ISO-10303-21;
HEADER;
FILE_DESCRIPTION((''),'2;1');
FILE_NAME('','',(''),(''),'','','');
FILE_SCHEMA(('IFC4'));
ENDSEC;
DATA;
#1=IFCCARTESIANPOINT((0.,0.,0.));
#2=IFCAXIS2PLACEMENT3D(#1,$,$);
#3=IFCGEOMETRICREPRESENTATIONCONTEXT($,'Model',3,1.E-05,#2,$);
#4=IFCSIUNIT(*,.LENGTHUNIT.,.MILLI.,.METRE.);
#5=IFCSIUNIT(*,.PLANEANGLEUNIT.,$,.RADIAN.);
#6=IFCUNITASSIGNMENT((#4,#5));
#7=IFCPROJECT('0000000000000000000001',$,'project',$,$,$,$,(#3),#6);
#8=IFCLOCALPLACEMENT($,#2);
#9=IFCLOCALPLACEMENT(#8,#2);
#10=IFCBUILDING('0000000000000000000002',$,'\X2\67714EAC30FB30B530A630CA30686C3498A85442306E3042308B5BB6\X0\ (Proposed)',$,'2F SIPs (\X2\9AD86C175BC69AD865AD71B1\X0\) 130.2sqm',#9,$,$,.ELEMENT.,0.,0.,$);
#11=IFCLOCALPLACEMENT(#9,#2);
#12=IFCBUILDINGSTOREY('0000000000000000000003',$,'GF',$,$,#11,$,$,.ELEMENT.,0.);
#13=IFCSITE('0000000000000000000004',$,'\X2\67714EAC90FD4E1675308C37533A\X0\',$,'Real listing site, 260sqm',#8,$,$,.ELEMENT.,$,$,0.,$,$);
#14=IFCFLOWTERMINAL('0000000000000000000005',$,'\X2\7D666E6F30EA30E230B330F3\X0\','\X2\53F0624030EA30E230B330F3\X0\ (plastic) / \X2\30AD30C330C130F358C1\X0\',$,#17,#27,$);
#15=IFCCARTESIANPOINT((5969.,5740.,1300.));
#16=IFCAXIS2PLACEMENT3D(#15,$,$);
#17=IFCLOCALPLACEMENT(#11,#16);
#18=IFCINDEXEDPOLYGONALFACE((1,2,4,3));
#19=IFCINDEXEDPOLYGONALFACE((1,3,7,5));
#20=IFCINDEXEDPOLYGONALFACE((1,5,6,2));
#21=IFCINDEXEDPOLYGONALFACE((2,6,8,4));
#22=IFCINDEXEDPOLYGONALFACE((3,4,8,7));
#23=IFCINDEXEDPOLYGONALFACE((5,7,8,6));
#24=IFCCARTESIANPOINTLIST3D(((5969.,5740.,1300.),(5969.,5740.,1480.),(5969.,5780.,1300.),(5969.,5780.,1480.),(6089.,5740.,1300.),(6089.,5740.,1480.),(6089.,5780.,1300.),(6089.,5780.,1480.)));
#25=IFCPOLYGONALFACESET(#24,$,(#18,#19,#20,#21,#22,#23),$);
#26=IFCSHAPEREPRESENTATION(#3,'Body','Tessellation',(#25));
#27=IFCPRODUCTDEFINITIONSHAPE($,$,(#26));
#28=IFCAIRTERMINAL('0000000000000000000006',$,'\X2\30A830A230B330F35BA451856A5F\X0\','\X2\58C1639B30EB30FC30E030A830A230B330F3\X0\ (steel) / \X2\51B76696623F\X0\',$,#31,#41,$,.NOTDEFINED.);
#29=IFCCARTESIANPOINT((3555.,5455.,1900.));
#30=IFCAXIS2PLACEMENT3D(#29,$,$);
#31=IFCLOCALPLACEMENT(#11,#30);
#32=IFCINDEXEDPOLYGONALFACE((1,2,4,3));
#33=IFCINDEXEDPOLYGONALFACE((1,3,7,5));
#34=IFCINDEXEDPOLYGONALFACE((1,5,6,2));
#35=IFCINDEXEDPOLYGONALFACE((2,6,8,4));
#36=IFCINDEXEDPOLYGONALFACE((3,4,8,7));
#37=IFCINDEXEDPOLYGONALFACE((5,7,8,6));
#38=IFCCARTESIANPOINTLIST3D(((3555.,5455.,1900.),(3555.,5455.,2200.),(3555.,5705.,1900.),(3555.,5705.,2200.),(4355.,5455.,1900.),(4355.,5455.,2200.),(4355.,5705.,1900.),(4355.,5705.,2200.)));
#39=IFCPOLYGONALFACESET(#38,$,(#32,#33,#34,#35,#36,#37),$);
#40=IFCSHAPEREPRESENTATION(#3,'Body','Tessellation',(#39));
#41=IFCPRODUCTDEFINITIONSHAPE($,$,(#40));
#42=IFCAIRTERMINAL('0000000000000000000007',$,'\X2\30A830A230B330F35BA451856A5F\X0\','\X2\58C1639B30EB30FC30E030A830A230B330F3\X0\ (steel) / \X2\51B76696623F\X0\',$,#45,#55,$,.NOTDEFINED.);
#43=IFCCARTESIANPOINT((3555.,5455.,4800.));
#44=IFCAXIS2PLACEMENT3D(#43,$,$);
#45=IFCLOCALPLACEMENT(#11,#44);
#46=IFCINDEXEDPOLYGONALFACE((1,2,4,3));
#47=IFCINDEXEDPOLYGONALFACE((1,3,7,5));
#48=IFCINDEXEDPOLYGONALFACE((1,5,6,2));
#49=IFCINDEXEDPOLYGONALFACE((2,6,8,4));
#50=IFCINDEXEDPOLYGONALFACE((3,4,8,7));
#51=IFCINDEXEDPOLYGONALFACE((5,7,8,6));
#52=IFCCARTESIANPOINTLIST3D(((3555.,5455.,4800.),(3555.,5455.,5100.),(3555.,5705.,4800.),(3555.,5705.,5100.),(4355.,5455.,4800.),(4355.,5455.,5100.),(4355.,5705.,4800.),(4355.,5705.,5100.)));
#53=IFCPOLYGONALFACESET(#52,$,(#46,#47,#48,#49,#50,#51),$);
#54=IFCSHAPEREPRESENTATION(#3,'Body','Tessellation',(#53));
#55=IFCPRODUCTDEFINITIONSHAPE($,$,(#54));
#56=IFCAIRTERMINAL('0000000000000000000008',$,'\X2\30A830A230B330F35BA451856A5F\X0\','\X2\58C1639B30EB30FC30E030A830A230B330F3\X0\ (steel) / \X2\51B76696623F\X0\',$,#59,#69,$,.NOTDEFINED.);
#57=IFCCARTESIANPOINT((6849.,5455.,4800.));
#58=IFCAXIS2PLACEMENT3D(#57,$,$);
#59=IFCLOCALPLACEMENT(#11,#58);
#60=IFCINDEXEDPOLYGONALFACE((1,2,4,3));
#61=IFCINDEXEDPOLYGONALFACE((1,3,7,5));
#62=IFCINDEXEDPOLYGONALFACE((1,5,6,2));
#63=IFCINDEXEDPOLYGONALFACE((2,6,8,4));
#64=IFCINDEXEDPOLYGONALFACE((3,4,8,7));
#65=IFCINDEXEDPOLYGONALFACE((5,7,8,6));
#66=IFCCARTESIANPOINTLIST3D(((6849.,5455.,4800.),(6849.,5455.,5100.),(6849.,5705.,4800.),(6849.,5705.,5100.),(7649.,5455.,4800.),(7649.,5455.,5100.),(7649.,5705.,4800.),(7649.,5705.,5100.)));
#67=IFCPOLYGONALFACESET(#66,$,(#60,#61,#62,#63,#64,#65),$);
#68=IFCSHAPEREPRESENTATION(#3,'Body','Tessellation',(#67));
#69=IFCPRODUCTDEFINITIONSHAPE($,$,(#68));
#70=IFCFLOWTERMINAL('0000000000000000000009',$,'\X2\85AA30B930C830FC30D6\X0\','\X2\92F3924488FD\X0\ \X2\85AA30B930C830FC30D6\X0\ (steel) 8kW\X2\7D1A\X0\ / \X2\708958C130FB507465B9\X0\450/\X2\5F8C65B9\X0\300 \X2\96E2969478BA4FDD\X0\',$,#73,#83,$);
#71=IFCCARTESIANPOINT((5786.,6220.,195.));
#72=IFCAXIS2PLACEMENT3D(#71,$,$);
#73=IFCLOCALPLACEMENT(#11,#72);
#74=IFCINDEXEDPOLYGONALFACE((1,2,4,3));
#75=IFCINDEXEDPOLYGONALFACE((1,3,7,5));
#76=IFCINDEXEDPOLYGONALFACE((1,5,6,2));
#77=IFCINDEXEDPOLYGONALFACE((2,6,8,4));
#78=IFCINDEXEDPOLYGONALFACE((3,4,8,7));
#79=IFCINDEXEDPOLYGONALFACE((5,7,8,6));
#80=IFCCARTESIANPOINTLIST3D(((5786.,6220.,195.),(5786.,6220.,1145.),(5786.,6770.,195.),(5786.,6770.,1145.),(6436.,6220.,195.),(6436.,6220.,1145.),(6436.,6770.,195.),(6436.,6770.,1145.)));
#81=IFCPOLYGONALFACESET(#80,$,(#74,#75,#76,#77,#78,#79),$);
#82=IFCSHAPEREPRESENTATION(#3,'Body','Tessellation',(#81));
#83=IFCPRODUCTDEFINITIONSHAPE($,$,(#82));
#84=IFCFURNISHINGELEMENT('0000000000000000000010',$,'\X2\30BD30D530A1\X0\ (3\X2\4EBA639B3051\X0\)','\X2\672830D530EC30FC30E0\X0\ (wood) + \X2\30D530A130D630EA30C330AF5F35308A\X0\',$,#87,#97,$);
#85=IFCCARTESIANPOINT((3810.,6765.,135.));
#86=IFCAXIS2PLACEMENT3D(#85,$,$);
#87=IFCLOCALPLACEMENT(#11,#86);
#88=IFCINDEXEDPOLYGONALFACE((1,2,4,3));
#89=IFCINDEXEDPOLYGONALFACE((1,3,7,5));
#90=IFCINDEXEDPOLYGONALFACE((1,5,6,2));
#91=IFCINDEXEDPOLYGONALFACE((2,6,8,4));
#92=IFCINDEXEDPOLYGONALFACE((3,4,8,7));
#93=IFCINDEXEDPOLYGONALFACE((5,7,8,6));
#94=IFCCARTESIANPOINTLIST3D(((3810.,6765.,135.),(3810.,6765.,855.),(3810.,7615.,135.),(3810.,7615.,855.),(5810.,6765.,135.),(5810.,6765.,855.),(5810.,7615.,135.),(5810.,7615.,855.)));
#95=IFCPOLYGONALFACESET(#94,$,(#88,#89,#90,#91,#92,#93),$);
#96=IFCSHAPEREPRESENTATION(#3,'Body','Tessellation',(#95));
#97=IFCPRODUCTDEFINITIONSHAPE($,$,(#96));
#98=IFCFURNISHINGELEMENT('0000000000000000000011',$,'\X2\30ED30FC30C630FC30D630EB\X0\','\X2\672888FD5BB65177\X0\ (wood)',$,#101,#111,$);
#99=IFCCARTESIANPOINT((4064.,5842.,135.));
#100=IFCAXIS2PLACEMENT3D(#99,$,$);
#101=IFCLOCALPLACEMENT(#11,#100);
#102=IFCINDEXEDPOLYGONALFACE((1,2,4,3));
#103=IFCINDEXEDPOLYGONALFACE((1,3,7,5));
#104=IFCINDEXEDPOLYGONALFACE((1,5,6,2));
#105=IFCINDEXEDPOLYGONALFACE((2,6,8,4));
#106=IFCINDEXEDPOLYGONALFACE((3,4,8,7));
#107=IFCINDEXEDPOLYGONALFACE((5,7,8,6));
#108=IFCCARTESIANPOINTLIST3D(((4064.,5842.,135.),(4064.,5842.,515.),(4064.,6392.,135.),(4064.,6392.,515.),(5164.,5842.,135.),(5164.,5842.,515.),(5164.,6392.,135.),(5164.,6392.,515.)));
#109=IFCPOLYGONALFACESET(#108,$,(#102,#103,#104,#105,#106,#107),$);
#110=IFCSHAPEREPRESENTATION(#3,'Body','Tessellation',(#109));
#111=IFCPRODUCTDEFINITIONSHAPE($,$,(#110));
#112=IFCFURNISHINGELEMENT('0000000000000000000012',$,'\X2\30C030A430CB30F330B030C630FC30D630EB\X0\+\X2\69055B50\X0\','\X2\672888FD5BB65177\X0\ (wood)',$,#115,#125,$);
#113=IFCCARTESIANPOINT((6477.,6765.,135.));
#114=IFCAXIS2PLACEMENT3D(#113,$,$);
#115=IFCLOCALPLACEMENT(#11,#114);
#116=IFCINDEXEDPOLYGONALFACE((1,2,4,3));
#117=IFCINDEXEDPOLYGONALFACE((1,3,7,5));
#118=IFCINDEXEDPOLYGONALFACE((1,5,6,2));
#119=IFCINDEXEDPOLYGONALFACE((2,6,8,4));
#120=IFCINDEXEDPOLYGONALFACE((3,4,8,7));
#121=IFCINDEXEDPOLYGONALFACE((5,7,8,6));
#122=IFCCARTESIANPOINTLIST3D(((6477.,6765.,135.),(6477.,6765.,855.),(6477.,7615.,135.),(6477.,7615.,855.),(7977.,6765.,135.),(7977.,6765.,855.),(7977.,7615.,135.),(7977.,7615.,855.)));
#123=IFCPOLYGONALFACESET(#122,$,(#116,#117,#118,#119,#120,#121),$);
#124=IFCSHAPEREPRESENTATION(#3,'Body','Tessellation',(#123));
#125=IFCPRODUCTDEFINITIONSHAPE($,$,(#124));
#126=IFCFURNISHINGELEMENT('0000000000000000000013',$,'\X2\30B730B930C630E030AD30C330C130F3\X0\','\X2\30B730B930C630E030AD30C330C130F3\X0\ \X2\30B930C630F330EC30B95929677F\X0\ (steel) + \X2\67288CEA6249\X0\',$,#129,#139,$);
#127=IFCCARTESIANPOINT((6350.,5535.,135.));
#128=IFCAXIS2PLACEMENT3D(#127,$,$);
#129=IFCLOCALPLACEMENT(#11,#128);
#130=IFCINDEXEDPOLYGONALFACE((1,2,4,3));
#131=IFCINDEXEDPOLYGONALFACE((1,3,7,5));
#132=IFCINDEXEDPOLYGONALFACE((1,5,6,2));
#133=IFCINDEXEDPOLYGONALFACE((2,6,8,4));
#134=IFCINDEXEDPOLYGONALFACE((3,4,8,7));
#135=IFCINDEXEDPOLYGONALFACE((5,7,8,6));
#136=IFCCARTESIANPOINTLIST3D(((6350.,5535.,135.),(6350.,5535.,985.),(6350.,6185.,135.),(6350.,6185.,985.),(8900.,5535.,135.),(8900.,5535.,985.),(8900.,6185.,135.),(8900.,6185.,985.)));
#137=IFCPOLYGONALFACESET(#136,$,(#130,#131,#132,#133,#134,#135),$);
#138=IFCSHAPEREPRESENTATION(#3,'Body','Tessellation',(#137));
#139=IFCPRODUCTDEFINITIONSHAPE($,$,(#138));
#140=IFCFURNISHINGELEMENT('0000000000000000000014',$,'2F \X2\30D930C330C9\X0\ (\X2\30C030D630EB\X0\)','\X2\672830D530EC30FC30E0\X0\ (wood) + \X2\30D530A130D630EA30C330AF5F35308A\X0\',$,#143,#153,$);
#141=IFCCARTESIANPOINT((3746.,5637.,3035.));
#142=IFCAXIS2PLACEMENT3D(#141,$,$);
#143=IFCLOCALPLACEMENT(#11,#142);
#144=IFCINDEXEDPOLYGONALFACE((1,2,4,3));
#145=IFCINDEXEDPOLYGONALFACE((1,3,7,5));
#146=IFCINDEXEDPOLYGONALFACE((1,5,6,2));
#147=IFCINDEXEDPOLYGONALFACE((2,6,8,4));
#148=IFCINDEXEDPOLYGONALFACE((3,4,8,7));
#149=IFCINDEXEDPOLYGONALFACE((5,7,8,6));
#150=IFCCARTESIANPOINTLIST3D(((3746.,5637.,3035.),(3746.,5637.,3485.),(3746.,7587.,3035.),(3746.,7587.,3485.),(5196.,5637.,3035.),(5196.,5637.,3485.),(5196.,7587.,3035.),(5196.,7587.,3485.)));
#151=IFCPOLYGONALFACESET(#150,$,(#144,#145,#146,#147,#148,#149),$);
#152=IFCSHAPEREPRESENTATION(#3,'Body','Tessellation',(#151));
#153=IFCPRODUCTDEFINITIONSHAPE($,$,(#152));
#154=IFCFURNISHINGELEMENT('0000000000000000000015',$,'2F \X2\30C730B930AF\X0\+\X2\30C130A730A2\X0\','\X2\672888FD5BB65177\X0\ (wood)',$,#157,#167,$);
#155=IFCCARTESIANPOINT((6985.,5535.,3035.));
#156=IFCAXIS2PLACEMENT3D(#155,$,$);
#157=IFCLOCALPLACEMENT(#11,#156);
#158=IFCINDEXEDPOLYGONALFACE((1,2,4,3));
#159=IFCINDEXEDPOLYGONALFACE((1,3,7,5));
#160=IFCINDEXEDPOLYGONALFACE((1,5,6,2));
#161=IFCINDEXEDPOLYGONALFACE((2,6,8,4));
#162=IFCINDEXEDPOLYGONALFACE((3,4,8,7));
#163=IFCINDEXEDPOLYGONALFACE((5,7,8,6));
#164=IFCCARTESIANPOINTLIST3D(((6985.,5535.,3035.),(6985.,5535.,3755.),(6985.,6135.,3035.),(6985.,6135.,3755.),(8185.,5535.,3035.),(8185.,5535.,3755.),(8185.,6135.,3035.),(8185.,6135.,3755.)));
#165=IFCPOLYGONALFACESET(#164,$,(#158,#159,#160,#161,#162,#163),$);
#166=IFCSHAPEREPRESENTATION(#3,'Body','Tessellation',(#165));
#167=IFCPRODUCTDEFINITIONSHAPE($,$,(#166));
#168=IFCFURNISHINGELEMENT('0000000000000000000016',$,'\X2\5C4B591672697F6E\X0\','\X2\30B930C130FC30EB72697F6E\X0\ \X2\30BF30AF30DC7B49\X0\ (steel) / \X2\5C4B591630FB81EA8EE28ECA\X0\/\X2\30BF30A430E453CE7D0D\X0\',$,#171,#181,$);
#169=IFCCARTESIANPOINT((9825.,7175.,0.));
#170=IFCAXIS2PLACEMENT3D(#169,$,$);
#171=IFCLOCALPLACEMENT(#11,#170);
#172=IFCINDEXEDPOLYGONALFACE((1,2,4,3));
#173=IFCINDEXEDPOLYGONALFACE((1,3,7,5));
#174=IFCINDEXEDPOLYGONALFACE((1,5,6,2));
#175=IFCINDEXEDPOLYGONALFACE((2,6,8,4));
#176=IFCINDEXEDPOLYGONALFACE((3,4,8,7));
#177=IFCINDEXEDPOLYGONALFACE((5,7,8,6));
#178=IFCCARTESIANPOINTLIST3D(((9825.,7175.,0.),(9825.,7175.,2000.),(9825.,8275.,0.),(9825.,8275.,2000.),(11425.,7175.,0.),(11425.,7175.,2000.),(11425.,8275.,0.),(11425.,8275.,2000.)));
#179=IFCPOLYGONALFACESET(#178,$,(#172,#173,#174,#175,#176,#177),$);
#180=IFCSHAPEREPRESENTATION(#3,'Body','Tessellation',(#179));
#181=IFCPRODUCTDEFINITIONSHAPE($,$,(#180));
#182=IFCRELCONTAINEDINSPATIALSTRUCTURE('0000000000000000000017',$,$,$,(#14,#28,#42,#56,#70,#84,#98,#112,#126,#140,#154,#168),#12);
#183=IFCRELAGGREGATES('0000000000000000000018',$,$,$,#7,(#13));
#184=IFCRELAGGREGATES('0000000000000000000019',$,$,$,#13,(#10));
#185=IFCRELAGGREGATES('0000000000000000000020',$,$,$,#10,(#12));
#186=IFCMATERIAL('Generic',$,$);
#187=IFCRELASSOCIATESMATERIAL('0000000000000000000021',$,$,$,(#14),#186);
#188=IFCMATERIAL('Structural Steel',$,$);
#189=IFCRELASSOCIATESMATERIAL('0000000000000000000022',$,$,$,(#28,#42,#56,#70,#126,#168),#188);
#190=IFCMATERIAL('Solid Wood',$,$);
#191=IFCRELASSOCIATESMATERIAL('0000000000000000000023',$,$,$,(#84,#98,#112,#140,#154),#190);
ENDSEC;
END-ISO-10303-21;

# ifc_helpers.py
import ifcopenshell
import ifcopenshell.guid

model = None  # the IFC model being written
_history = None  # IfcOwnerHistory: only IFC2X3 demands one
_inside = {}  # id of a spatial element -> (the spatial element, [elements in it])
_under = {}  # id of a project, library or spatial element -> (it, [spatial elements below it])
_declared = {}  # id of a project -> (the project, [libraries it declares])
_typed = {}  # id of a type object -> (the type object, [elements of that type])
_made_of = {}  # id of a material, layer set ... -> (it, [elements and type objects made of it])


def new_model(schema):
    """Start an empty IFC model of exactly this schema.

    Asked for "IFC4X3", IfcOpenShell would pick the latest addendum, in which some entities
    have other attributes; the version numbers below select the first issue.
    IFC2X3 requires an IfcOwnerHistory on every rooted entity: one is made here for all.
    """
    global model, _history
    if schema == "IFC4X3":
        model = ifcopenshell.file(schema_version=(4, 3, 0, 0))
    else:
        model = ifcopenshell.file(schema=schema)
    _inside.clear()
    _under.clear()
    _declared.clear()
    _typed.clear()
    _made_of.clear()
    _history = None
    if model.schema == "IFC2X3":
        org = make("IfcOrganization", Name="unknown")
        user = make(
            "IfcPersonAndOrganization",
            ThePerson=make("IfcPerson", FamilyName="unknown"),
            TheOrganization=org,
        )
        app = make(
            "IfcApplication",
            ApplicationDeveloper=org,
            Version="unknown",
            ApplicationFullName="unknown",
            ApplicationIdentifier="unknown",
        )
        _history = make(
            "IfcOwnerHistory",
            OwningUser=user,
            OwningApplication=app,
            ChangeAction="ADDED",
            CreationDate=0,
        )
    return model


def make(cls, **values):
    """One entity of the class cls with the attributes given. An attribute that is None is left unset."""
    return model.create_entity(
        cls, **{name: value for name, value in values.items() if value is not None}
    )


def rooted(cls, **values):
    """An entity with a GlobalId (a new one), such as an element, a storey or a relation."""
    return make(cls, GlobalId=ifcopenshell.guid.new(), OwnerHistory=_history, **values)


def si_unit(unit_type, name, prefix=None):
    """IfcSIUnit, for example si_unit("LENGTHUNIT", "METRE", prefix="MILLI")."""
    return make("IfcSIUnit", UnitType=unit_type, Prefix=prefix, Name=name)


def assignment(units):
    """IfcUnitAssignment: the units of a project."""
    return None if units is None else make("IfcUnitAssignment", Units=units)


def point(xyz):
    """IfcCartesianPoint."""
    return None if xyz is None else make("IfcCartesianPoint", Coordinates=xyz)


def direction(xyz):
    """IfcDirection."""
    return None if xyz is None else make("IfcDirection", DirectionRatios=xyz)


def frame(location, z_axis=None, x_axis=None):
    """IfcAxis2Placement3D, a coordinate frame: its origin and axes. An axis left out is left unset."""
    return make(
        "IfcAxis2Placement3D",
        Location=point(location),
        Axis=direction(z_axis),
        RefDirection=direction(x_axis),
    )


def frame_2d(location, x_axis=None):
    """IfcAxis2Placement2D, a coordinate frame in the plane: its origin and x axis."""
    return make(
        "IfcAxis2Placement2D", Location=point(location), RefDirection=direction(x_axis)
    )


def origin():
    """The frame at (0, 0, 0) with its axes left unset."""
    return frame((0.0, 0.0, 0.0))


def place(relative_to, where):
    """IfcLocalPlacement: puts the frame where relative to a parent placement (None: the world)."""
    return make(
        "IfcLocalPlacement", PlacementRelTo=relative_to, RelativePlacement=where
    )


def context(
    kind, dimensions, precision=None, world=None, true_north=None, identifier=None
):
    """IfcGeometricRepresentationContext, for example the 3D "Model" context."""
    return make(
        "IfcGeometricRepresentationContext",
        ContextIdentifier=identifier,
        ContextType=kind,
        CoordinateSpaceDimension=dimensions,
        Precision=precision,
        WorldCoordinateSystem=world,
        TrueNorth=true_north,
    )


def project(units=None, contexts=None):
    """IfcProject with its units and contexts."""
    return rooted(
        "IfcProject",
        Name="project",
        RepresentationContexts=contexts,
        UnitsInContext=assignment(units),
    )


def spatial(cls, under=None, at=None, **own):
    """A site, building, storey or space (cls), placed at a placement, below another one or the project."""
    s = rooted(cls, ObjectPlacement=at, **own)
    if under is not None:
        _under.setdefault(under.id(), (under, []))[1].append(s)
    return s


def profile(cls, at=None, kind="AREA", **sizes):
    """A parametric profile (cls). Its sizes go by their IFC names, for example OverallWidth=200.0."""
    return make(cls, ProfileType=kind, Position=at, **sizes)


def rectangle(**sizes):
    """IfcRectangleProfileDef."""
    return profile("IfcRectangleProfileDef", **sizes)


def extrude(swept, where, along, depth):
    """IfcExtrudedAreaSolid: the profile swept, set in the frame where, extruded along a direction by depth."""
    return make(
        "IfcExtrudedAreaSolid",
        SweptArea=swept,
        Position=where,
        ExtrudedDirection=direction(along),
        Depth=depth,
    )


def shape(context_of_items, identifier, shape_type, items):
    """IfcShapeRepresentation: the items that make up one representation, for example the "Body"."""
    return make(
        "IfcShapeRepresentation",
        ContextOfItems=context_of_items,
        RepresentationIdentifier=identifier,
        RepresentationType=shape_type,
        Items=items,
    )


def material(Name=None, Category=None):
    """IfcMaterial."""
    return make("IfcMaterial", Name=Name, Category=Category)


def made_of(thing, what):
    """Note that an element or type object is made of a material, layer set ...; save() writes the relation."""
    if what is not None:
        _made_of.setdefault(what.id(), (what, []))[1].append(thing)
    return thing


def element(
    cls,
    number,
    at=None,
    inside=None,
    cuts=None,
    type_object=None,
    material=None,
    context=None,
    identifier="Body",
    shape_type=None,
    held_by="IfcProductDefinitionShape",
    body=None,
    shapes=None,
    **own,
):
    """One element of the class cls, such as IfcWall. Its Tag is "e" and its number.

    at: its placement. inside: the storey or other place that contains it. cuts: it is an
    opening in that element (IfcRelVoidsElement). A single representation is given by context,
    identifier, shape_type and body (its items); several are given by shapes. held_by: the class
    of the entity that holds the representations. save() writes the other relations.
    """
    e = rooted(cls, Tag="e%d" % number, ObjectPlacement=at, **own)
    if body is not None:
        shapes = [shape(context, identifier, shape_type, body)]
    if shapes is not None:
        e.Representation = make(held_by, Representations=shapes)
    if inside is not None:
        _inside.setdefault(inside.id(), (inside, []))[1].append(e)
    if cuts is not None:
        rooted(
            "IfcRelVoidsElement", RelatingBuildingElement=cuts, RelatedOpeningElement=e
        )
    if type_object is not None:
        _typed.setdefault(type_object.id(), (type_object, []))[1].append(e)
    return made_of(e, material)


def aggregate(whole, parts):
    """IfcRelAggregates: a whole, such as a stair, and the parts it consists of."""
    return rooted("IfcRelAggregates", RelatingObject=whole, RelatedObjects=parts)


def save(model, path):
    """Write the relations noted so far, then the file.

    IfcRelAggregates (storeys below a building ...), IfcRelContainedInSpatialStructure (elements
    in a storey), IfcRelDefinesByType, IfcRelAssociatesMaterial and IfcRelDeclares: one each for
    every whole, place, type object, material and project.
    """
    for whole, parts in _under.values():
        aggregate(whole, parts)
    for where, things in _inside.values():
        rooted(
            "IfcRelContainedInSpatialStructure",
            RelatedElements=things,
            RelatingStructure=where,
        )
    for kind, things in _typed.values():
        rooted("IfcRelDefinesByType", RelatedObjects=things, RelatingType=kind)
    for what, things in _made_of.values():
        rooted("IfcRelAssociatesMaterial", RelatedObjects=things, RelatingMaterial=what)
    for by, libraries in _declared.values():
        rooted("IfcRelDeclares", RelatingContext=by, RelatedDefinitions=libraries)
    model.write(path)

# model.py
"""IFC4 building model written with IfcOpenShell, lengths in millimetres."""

from ifc_helpers import new_model, si_unit, frame, frame_2d, origin, place, context, project, spatial, rectangle, extrude, material, element, save


model = new_model("IFC4")

# Units and contexts
model_context = context("Model", 3, precision=1e-05, world=origin())
ifc_project = project(units=[si_unit("LENGTHUNIT", "METRE", prefix="MILLI"), si_unit("PLANEANGLEUNIT", "RADIAN")], contexts=[model_context])

# Site, building, storey
site_placement = place(None, origin())
site = spatial("IfcSite", under=ifc_project, at=site_placement, Name="東京都世田谷区", ObjectType="Real listing site, 260sqm", CompositionType="ELEMENT", RefElevation=0.0)
building_placement = place(site_placement, origin())
building = spatial("IfcBuilding", under=site, at=building_placement, Name="東京・サウナと水風呂のある家 (Proposed)", ObjectType="2F SIPs (高気密高断熱) 130.2sqm", CompositionType="ELEMENT", ElevationOfRefHeight=0.0, ElevationOfTerrain=0.0)
storey_placement = place(building_placement, origin())
storey = spatial("IfcBuildingStorey", under=building, at=storey_placement, Name="GF", CompositionType="ELEMENT", Elevation=0.0)

# Shared definitions
ifc_material_1 = material(Name="Solid Wood")

# Shared definitions
ifc_material_2 = material(Name="Structural Steel")

# Shared definitions
ifc_material_3 = material(Name="Generic")

# Flow terminal
flow_terminal_1_placement = place(storey_placement, frame((5969.0, 5740.0, 1300.0)))
element("IfcFlowTerminal", 1, at=flow_terminal_1_placement, inside=storey, material=ifc_material_3, Name="給湯リモコン", Description="台所リモコン (plastic) / キッチン壁", context=model_context, shape_type="SweptSolid", body=[
    extrude(rectangle(XDim=120.0, YDim=40.0, at=frame_2d((60.0, 20.0))), frame((5969.0, 5740.0, 1300.0)), (0.0, 0.0, 1.0), 180.0),
])

# Air terminals
air_terminal_1_placement = place(storey_placement, frame((3555.0, 5455.0, 1900.0)))
element("IfcAirTerminal", 2, at=air_terminal_1_placement, inside=storey, material=ifc_material_2, Name="エアコン室内機", Description="壁掛ルームエアコン (steel) / 冷暖房", PredefinedType="NOTDEFINED", context=model_context, shape_type="SweptSolid", body=[
    extrude(rectangle(XDim=800.0, YDim=250.0, at=frame_2d((400.0, 125.0))), frame((3555.0, 5455.0, 1900.0)), (0.0, 0.0, 1.0), 300.0),
])
air_terminal_2_placement = place(storey_placement, frame((3555.0, 5455.0, 4800.0)))
element("IfcAirTerminal", 3, at=air_terminal_2_placement, inside=storey, material=ifc_material_2, Name="エアコン室内機", Description="壁掛ルームエアコン (steel) / 冷暖房", PredefinedType="NOTDEFINED", context=model_context, shape_type="SweptSolid", body=[
    extrude(rectangle(XDim=800.0, YDim=250.0, at=frame_2d((400.0, 125.0))), frame((3555.0, 5455.0, 4800.0)), (0.0, 0.0, 1.0), 300.0),
])
air_terminal_3_placement = place(storey_placement, frame((6849.0, 5455.0, 4800.0)))
element("IfcAirTerminal", 4, at=air_terminal_3_placement, inside=storey, material=ifc_material_2, Name="エアコン室内機", Description="壁掛ルームエアコン (steel) / 冷暖房", PredefinedType="NOTDEFINED", context=model_context, shape_type="SweptSolid", body=[
    extrude(rectangle(XDim=800.0, YDim=250.0, at=frame_2d((400.0, 125.0))), frame((6849.0, 5455.0, 4800.0)), (0.0, 0.0, 1.0), 300.0),
])

# Flow terminal
flow_terminal_2_placement = place(storey_placement, frame((5786.0, 6220.0, 195.0)))
element("IfcFlowTerminal", 5, at=flow_terminal_2_placement, inside=storey, material=ifc_material_2, Name="薪ストーブ", Description="鋳鉄製 薪ストーブ (steel) 8kW級 / 炉壁・側方450/後方300 離隔確保", context=model_context, shape_type="SweptSolid", body=[
    extrude(rectangle(XDim=650.0, YDim=550.0, at=frame_2d((325.0, 275.0))), frame((5786.0, 6220.0, 195.0)), (0.0, 0.0, 1.0), 950.0),
])

# Furnishing elements
furnishing_1_placement = place(storey_placement, frame((3810.0, 6765.0, 135.0)))
element("IfcFurnishingElement", 6, at=furnishing_1_placement, inside=storey, material=ifc_material_1, Name="ソファ (3人掛け)", Description="木フレーム (wood) + ファブリック張り", context=model_context, shape_type="SweptSolid", body=[
    extrude(rectangle(XDim=2000.0, YDim=850.0, at=frame_2d((1000.0, 425.0))), frame((3810.0, 6765.0, 135.0)), (0.0, 0.0, 1.0), 720.0),
])
furnishing_2_placement = place(storey_placement, frame((4064.0, 5842.0, 135.0)))
element("IfcFurnishingElement", 7, at=furnishing_2_placement, inside=storey, material=ifc_material_1, Name="ローテーブル", Description="木製家具 (wood)", context=model_context, shape_type="SweptSolid", body=[
    extrude(rectangle(XDim=1100.0, YDim=550.0, at=frame_2d((550.0, 275.0))), frame((4064.0, 5842.0, 135.0)), (0.0, 0.0, 1.0), 380.0),
])
furnishing_3_placement = place(storey_placement, frame((6477.0, 6765.0, 135.0)))
element("IfcFurnishingElement", 8, at=furnishing_3_placement, inside=storey, material=ifc_material_1, Name="ダイニングテーブル+椅子", Description="木製家具 (wood)", context=model_context, shape_type="SweptSolid", body=[
    extrude(rectangle(XDim=1500.0, YDim=850.0, at=frame_2d((750.0, 425.0))), frame((6477.0, 6765.0, 135.0)), (0.0, 0.0, 1.0), 720.0),
])
furnishing_4_placement = place(storey_placement, frame((6350.0, 5535.0, 135.0)))
element("IfcFurnishingElement", 9, at=furnishing_4_placement, inside=storey, material=ifc_material_2, Name="システムキッチン", Description="システムキッチン ステンレス天板 (steel) + 木質扉", context=model_context, shape_type="SweptSolid", body=[
    extrude(rectangle(XDim=2550.0, YDim=650.0, at=frame_2d((1275.0, 325.0))), frame((6350.0, 5535.0, 135.0)), (0.0, 0.0, 1.0), 850.0),
])
furnishing_5_placement = place(storey_placement, frame((3746.0, 5637.0, 3035.0)))
element("IfcFurnishingElement", 10, at=furnishing_5_placement, inside=storey, material=ifc_material_1, Name="2F ベッド (ダブル)", Description="木フレーム (wood) + ファブリック張り", context=model_context, shape_type="SweptSolid", body=[
    extrude(rectangle(XDim=1450.0, YDim=1950.0, at=frame_2d((725.0, 975.0))), frame((3746.0, 5637.0, 3035.0)), (0.0, 0.0, 1.0), 450.0),
])
furnishing_6_placement = place(storey_placement, frame((6985.0, 5535.0, 3035.0)))
element("IfcFurnishingElement", 11, at=furnishing_6_placement, inside=storey, material=ifc_material_1, Name="2F デスク+チェア", Description="木製家具 (wood)", context=model_context, shape_type="SweptSolid", body=[
    extrude(rectangle(XDim=1200.0, YDim=600.0, at=frame_2d((600.0, 300.0))), frame((6985.0, 5535.0, 3035.0)), (0.0, 0.0, 1.0), 720.0),
])
furnishing_7_placement = place(storey_placement, frame((9825.0, 7175.0, 0.0)))
element("IfcFurnishingElement", 12, at=furnishing_7_placement, inside=storey, material=ifc_material_2, Name="屋外物置", Description="スチール物置 タクボ等 (steel) / 屋外・自転車/タイヤ収納", context=model_context, shape_type="SweptSolid", body=[
    extrude(rectangle(XDim=1600.0, YDim=1100.0, at=frame_2d((800.0, 550.0))), frame((9825.0, 7175.0, 0.0)), (0.0, 0.0, 1.0), 2000.0),
])

save(model, "model.ifc")
